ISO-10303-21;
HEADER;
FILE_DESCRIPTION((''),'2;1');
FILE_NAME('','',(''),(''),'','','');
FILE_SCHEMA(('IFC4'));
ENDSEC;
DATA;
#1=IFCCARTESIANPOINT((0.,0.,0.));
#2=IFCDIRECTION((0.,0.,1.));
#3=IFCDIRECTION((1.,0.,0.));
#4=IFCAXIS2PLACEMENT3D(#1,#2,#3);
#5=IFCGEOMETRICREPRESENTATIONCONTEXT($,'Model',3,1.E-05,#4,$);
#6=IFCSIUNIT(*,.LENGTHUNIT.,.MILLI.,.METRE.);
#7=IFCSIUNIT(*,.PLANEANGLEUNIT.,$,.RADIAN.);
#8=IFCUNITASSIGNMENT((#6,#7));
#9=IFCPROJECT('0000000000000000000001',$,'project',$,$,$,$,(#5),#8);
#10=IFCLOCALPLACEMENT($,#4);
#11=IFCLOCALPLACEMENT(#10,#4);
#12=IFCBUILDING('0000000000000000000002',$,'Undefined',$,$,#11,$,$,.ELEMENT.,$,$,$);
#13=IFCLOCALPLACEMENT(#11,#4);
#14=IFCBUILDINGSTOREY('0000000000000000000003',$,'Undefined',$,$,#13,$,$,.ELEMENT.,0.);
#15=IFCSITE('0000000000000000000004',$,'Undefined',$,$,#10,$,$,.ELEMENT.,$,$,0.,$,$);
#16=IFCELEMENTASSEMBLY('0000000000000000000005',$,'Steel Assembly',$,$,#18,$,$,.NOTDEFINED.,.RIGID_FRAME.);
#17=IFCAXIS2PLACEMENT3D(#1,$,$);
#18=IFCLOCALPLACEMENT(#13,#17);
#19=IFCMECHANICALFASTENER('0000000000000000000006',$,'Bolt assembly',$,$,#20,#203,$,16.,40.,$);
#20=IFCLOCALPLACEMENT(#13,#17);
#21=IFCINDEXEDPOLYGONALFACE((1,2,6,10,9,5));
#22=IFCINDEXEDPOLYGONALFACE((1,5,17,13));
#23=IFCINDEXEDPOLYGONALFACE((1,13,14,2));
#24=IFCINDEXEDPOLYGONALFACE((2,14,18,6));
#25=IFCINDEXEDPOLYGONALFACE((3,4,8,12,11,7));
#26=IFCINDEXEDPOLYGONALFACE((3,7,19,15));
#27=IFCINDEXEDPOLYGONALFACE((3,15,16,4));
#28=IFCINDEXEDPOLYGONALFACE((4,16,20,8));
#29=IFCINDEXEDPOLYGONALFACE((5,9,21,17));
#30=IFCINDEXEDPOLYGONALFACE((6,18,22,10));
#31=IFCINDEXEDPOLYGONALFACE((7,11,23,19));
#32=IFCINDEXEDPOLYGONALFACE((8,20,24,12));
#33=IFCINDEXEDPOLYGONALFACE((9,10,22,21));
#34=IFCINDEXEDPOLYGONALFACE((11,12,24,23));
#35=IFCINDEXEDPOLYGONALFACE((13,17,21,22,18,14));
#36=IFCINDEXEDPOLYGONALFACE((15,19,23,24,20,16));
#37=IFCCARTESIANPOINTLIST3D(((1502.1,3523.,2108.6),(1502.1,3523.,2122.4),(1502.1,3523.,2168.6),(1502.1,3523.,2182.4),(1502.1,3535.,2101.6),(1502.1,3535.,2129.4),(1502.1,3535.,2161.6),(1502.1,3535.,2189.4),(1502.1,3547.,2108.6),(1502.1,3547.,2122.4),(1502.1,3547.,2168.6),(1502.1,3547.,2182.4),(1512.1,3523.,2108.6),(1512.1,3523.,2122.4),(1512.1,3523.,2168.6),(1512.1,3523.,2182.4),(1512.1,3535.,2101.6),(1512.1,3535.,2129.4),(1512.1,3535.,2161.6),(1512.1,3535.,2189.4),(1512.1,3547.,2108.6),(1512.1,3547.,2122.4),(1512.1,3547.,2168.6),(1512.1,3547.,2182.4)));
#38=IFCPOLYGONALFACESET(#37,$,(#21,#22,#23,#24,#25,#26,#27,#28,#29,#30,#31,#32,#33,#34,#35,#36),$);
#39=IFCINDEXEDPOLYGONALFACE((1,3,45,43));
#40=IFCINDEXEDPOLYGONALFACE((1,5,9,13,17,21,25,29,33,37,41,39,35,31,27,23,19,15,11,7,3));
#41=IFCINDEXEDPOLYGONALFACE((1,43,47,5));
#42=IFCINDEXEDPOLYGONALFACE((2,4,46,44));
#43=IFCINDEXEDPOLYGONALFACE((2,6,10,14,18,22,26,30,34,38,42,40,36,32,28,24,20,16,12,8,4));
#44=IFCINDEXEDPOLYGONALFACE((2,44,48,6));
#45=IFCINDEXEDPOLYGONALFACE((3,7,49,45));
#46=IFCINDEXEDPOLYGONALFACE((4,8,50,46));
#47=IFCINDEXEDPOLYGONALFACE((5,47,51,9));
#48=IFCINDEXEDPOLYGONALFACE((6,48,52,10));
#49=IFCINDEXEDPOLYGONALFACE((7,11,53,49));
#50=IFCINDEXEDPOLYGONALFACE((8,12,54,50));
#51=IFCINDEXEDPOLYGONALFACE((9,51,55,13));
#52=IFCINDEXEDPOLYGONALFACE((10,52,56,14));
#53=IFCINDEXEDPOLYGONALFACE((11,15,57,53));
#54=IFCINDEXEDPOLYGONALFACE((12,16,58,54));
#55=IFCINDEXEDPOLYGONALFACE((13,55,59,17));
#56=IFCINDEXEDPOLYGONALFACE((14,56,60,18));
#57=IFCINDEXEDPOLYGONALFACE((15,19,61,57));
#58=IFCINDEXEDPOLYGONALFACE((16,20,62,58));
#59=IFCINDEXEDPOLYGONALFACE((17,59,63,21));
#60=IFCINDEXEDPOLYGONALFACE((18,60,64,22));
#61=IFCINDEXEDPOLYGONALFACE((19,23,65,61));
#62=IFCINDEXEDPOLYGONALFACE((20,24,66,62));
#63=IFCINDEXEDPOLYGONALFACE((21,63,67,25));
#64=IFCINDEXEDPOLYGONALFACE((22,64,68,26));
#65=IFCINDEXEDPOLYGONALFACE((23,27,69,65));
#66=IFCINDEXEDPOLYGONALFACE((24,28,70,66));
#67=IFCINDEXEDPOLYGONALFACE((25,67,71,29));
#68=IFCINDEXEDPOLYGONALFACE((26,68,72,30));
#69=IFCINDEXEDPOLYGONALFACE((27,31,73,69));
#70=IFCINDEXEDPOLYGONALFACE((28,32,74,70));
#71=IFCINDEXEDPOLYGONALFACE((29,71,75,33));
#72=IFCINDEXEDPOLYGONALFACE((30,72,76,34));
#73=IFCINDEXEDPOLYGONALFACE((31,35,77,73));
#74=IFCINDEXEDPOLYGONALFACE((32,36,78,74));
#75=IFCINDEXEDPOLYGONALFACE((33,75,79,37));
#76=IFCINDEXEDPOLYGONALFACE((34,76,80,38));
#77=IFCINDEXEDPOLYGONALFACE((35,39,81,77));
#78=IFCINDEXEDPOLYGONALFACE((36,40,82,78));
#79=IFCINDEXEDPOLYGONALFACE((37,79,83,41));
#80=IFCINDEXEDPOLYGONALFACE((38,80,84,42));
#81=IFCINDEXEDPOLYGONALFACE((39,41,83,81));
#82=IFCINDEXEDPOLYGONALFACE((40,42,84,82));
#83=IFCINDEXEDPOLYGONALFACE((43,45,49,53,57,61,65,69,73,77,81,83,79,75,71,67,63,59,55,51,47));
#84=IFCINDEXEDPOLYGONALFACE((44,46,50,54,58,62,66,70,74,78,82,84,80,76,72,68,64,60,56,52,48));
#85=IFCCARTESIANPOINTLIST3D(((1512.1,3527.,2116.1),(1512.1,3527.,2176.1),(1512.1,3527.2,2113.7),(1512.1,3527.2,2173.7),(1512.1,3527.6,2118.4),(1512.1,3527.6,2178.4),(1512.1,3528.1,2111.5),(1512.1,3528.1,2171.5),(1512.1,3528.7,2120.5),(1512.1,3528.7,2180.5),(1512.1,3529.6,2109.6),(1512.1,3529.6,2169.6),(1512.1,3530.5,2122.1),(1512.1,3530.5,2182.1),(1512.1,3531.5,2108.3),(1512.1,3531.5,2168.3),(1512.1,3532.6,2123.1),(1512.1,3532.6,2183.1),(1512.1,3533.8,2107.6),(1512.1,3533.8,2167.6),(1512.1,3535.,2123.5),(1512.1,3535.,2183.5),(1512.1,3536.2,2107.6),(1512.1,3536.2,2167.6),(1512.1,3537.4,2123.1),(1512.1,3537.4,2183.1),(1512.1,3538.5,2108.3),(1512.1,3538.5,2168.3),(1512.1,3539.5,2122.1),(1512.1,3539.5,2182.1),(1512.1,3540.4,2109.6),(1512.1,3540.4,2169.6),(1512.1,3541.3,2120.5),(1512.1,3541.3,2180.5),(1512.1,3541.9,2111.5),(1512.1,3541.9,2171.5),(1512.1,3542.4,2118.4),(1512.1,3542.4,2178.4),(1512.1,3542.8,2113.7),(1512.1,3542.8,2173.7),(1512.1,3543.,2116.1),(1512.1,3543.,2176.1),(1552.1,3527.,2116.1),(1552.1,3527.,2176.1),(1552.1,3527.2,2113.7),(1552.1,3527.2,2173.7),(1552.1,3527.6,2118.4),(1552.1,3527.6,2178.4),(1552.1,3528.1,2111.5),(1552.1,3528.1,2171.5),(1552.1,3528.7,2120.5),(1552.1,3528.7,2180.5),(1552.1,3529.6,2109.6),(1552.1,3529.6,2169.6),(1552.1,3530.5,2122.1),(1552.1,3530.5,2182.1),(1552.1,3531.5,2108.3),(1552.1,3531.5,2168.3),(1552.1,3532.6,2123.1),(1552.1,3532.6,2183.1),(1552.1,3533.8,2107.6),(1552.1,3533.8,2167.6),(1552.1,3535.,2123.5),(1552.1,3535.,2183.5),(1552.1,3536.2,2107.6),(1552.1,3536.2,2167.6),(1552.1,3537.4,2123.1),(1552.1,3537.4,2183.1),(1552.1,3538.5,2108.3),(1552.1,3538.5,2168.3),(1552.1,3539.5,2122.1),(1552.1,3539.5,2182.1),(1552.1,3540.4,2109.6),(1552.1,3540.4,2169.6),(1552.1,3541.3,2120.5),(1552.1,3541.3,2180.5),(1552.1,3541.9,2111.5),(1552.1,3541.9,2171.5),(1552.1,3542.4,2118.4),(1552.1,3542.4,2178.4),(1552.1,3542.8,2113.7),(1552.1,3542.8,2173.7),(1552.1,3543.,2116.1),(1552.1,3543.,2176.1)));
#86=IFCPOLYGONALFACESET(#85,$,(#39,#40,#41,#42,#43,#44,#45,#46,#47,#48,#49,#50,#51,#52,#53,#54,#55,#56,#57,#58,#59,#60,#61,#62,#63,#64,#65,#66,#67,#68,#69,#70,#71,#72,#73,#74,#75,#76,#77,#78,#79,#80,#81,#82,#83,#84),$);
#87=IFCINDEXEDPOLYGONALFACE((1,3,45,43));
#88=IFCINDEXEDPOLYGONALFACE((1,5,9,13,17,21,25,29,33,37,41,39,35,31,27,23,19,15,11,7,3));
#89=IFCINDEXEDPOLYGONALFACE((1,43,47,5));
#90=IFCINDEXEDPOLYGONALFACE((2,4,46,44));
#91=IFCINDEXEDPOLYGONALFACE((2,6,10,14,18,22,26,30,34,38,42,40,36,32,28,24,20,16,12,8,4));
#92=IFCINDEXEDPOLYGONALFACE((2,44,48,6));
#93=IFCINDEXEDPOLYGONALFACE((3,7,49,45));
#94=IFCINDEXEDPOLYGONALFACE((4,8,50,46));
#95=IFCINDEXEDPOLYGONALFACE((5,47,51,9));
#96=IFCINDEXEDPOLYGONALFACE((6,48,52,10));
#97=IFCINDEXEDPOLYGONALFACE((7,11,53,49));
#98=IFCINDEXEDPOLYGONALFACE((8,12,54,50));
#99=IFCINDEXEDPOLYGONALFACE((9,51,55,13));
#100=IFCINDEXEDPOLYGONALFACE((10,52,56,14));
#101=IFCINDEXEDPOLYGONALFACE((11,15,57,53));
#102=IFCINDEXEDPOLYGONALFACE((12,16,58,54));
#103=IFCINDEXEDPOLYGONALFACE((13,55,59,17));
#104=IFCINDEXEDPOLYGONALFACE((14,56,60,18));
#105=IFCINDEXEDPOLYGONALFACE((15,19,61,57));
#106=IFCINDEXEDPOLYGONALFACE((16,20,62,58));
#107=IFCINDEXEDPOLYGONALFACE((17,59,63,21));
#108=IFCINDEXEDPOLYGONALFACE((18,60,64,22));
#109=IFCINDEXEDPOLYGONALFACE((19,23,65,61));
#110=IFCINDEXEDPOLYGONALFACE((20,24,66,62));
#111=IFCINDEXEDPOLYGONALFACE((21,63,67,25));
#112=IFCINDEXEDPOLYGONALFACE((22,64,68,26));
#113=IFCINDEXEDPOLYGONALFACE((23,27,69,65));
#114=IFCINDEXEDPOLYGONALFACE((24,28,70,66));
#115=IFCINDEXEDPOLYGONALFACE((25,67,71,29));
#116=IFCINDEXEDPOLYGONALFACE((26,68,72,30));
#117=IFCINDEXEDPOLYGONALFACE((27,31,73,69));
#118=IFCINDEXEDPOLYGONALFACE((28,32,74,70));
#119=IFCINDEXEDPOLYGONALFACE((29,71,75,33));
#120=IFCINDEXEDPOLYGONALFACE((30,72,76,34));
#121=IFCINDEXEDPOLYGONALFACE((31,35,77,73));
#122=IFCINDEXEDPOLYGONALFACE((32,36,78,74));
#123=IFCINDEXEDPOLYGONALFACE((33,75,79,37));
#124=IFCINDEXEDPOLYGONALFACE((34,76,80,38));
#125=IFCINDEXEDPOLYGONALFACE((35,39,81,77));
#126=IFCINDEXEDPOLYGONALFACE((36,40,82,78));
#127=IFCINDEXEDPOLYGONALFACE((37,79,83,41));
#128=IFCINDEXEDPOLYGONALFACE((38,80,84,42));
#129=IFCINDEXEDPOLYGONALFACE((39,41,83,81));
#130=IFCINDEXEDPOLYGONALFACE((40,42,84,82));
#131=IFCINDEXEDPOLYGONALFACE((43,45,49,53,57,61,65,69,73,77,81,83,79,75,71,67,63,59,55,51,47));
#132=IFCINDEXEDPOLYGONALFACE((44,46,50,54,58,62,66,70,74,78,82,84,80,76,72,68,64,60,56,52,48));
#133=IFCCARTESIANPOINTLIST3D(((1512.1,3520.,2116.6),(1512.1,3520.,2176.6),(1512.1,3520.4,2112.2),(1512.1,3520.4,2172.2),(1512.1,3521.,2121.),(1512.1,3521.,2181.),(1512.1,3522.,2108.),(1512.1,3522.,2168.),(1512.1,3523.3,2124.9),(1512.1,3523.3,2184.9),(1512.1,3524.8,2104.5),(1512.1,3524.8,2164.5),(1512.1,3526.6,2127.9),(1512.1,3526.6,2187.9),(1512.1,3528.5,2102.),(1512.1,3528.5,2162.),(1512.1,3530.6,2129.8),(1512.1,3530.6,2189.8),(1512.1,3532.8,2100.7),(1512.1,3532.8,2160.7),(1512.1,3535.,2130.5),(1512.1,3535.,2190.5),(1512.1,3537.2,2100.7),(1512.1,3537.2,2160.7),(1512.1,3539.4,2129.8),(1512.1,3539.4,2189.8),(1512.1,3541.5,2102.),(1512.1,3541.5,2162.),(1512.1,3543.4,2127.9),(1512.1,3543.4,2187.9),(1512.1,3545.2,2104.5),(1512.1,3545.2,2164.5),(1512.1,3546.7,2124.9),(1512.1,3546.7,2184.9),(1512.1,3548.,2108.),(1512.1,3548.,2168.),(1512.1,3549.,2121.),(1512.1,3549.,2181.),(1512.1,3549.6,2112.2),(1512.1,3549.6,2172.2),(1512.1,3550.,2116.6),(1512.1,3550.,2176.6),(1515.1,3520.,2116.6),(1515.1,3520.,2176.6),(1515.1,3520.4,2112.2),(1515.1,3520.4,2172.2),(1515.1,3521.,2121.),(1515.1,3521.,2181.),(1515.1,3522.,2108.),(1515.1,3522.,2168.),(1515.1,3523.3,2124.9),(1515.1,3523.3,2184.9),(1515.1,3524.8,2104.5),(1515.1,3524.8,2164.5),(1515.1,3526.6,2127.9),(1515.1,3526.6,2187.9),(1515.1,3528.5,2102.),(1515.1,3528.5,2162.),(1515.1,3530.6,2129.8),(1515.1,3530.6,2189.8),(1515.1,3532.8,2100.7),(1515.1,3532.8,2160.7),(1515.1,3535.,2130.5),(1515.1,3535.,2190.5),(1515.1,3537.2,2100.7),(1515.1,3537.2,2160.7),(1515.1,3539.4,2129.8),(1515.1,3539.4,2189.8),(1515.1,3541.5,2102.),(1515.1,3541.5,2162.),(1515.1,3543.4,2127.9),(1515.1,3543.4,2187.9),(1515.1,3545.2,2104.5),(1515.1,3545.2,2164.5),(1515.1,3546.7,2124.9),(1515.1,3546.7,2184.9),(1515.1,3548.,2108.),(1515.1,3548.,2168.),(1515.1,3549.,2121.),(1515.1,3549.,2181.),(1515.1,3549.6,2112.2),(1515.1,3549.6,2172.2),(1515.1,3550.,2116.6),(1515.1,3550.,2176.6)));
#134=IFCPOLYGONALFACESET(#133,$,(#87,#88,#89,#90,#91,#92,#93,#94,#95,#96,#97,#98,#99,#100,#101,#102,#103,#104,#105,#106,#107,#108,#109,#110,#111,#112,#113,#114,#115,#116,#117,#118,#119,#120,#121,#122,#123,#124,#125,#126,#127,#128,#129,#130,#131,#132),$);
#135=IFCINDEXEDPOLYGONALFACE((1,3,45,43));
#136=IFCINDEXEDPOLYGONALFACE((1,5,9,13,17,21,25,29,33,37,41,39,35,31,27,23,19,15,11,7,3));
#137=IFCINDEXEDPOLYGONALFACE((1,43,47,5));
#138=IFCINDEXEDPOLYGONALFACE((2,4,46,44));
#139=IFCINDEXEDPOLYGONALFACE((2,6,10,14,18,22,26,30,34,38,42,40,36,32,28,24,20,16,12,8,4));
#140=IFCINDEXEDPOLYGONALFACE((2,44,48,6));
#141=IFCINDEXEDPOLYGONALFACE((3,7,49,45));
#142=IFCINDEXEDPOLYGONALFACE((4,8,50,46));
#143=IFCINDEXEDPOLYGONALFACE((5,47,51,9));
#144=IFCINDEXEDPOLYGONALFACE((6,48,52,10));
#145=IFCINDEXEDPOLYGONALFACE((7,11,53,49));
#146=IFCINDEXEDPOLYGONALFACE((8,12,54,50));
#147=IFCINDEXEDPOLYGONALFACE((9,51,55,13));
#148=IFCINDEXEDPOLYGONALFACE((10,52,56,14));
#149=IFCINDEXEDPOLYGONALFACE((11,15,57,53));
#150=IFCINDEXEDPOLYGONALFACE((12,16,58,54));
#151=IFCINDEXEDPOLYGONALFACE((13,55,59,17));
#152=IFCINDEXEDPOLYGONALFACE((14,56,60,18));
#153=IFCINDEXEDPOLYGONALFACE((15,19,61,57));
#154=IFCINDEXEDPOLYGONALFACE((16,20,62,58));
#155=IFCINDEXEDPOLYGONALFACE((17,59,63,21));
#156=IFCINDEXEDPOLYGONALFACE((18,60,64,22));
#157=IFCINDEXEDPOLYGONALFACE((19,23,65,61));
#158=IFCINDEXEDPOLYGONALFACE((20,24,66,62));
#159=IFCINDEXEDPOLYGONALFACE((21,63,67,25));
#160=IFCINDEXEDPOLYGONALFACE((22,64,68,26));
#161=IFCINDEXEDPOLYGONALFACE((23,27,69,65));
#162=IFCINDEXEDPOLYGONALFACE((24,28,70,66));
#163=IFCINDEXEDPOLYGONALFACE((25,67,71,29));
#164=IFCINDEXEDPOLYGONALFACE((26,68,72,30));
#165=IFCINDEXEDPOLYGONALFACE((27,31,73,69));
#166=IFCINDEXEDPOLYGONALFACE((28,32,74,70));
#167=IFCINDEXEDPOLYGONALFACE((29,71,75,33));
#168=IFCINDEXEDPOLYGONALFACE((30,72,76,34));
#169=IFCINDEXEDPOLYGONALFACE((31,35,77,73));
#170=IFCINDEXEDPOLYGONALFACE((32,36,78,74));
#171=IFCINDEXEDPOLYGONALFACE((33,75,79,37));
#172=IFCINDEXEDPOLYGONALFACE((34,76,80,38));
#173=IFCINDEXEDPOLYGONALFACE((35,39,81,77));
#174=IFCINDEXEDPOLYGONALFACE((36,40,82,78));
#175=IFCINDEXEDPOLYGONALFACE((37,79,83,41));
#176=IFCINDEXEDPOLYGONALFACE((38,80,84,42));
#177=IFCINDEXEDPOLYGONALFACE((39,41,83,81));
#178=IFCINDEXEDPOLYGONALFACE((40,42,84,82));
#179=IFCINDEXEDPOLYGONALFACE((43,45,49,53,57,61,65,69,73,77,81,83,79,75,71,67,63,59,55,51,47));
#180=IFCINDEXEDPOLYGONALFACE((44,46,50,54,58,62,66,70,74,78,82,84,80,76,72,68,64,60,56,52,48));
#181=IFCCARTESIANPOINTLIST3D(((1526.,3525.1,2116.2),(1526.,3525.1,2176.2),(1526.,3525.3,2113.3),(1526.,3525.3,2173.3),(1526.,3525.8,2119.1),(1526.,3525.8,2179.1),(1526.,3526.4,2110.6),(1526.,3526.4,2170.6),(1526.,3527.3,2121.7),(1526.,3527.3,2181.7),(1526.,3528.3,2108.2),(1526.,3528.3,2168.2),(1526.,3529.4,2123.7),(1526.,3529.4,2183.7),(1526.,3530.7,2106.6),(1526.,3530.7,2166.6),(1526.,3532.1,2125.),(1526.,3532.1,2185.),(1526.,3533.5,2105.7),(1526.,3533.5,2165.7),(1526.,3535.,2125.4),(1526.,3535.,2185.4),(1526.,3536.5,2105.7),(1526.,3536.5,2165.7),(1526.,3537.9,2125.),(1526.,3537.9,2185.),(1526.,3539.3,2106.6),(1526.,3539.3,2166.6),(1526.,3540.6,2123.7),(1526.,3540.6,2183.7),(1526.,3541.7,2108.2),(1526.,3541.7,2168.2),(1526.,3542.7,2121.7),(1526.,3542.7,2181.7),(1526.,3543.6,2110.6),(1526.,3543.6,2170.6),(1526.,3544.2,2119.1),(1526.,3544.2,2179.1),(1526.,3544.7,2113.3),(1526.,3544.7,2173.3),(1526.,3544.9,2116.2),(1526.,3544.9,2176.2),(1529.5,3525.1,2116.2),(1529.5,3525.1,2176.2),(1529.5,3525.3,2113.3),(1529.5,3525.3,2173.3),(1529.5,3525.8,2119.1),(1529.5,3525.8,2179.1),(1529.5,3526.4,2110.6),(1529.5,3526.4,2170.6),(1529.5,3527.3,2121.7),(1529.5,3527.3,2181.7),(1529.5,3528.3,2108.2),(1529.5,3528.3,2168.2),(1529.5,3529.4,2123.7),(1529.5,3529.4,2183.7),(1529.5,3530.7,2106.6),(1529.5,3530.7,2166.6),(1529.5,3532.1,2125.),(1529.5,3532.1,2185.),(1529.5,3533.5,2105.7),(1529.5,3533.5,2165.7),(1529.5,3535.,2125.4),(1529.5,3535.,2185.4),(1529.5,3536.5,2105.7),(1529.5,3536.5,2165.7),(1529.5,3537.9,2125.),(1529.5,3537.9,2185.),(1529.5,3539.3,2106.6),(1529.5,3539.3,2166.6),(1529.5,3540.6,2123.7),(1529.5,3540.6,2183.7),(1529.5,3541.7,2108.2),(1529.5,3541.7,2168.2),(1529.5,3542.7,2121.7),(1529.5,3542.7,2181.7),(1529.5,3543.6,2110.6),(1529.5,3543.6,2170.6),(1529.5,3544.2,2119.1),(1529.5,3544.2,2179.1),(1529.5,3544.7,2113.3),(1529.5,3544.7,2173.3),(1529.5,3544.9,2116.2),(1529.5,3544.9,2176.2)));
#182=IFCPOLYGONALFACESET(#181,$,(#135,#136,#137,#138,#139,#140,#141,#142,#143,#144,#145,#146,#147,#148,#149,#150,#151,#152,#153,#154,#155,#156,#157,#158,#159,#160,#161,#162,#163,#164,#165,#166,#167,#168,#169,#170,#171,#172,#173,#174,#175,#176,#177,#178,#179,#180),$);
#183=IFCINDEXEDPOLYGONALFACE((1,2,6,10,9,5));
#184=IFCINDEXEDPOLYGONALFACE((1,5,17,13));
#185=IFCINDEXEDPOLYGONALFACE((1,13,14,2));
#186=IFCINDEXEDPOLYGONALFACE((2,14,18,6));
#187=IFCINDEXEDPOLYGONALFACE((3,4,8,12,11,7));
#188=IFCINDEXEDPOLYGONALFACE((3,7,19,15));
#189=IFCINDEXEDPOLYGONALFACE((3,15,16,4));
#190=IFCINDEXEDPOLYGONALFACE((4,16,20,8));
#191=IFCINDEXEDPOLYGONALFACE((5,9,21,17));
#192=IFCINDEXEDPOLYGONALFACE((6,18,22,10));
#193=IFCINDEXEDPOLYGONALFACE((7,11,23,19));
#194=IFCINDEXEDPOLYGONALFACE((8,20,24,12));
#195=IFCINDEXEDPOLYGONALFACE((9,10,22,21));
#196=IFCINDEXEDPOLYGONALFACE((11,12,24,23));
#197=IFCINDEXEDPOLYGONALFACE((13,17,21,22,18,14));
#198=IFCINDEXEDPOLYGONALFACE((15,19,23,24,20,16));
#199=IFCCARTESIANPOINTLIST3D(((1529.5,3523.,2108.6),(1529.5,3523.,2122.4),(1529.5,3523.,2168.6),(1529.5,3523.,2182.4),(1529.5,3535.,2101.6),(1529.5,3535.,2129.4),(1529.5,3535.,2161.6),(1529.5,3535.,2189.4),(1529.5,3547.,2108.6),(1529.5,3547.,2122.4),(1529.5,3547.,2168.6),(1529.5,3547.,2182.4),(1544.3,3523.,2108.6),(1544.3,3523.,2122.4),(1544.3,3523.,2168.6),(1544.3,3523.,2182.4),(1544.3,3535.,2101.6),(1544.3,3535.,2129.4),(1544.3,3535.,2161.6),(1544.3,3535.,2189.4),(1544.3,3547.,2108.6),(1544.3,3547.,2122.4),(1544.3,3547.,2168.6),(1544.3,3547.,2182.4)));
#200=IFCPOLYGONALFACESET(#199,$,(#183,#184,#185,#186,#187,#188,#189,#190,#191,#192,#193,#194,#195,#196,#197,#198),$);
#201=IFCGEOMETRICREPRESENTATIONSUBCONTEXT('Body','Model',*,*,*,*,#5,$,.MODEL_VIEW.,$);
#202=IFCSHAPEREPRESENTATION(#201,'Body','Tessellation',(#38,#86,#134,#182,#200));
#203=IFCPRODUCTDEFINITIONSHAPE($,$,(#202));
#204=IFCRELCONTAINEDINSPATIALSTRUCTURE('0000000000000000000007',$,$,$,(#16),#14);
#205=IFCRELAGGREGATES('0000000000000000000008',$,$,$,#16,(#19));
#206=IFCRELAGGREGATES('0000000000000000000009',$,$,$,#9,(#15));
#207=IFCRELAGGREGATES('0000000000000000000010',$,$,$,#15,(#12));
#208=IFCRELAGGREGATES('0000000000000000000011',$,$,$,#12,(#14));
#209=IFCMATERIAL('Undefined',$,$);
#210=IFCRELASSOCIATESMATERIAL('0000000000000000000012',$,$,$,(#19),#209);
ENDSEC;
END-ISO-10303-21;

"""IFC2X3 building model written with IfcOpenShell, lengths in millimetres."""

from ifc_helpers import new_model, si_unit, frame, origin_with_axes, origin_2d_with_axis, place, context, subcontext, project, spatial, polyline, circle, outline, extrude, source, transform, mapped, material, element, aggregate, save


model = new_model("IFC2X3")

# Units and contexts
model_context = context("Model", 3, precision=1e-05, world=origin_with_axes())
body_context = subcontext(model_context, "Body", "Model", "MODEL_VIEW")
ifc_project = project(units=[si_unit("LENGTHUNIT", "METRE", prefix="MILLI"), si_unit("PLANEANGLEUNIT", "RADIAN")], contexts=[model_context])

# Site, building, storey
site_placement = place(None, origin_with_axes())
site = spatial("IfcSite", under=ifc_project, at=site_placement, Name="Undefined", CompositionType="ELEMENT", RefElevation=0.0)
building_placement = place(site_placement, origin_with_axes())
building = spatial("IfcBuilding", under=site, at=building_placement, Name="Undefined", CompositionType="ELEMENT")
storey_placement = place(building_placement, origin_with_axes())
storey = spatial("IfcBuildingStorey", under=building, at=storey_placement, Name="Undefined", CompositionType="ELEMENT", Elevation=0.0)

# Element assembly, mechanical fastener
assembly_1_placement = place(storey_placement, origin_with_axes())
assembly_1 = element("IfcElementAssembly", 1, at=assembly_1_placement, inside=storey, Name="Steel Assembly", AssemblyPlace="NOTDEFINED", PredefinedType="RIGID_FRAME")
ifc_material_1 = material(Name="Undefined")
shared_shape_1 = source(origin_with_axes(), body_context, "Body", "SweptSolid", [
    extrude(outline(polyline([(13.9, 0.0), (6.9, 12.0), (-6.9, 12.0), (-13.9, 0.0), (-6.9, -12.0), (6.9, -12.0), (13.9, 0.0)])), frame((0.0, -17.9, 0.0), z_axis=(0.0, 1.0, 0.0), x_axis=(1.0, 0.0, 0.0)), (0.0, 0.0, 1.0), 10.0),
    extrude(circle(Radius=8.0, at=origin_2d_with_axis()), frame((0.0, -7.9, 0.0), z_axis=(0.0, 1.0, 0.0), x_axis=(1.0, 0.0, 0.0)), (0.0, 0.0, 1.0), 40.0),
    extrude(circle(Radius=15.0, at=origin_2d_with_axis()), frame((0.0, -7.9, 0.0), z_axis=(0.0, 1.0, 0.0), x_axis=(1.0, 0.0, 0.0)), (0.0, 0.0, 1.0), 3.0),
    extrude(circle(Radius=9.9, at=origin_2d_with_axis()), frame((0.0, 6.0, 0.0), z_axis=(0.0, 1.0, 0.0), x_axis=(1.0, 0.0, 0.0)), (0.0, 0.0, 1.0), 3.5),
    extrude(outline(polyline([(13.9, 0.0), (6.9, 12.0), (-6.9, 12.0), (-13.9, 0.0), (-6.9, -12.0), (6.9, -12.0), (13.9, 0.0)])), frame((0.0, 9.5, 0.0), z_axis=(0.0, 1.0, 0.0), x_axis=(1.0, 0.0, 0.0)), (0.0, 0.0, 1.0), 14.8),
])
mechanical_fastener_1_placement = place(assembly_1_placement, frame((1520.0, 3535.0, 2115.5), z_axis=(0.0, 1.0, 0.0), x_axis=(0.0, 0.0, 1.0)))
mechanical_fastener_1 = element("IfcMechanicalFastener", 2, at=mechanical_fastener_1_placement, material=ifc_material_1, Name="Bolt assembly", NominalDiameter=16.0, NominalLength=40.0, context=body_context, shape_type="MappedRepresentation", body=[
    mapped(shared_shape_1, transform((0.0, 0.0, 0.0))),
    mapped(shared_shape_1, transform((60.0, 0.0, 0.0))),
])
aggregate(assembly_1, [mechanical_fastener_1])

save(model, "model.ifc")
